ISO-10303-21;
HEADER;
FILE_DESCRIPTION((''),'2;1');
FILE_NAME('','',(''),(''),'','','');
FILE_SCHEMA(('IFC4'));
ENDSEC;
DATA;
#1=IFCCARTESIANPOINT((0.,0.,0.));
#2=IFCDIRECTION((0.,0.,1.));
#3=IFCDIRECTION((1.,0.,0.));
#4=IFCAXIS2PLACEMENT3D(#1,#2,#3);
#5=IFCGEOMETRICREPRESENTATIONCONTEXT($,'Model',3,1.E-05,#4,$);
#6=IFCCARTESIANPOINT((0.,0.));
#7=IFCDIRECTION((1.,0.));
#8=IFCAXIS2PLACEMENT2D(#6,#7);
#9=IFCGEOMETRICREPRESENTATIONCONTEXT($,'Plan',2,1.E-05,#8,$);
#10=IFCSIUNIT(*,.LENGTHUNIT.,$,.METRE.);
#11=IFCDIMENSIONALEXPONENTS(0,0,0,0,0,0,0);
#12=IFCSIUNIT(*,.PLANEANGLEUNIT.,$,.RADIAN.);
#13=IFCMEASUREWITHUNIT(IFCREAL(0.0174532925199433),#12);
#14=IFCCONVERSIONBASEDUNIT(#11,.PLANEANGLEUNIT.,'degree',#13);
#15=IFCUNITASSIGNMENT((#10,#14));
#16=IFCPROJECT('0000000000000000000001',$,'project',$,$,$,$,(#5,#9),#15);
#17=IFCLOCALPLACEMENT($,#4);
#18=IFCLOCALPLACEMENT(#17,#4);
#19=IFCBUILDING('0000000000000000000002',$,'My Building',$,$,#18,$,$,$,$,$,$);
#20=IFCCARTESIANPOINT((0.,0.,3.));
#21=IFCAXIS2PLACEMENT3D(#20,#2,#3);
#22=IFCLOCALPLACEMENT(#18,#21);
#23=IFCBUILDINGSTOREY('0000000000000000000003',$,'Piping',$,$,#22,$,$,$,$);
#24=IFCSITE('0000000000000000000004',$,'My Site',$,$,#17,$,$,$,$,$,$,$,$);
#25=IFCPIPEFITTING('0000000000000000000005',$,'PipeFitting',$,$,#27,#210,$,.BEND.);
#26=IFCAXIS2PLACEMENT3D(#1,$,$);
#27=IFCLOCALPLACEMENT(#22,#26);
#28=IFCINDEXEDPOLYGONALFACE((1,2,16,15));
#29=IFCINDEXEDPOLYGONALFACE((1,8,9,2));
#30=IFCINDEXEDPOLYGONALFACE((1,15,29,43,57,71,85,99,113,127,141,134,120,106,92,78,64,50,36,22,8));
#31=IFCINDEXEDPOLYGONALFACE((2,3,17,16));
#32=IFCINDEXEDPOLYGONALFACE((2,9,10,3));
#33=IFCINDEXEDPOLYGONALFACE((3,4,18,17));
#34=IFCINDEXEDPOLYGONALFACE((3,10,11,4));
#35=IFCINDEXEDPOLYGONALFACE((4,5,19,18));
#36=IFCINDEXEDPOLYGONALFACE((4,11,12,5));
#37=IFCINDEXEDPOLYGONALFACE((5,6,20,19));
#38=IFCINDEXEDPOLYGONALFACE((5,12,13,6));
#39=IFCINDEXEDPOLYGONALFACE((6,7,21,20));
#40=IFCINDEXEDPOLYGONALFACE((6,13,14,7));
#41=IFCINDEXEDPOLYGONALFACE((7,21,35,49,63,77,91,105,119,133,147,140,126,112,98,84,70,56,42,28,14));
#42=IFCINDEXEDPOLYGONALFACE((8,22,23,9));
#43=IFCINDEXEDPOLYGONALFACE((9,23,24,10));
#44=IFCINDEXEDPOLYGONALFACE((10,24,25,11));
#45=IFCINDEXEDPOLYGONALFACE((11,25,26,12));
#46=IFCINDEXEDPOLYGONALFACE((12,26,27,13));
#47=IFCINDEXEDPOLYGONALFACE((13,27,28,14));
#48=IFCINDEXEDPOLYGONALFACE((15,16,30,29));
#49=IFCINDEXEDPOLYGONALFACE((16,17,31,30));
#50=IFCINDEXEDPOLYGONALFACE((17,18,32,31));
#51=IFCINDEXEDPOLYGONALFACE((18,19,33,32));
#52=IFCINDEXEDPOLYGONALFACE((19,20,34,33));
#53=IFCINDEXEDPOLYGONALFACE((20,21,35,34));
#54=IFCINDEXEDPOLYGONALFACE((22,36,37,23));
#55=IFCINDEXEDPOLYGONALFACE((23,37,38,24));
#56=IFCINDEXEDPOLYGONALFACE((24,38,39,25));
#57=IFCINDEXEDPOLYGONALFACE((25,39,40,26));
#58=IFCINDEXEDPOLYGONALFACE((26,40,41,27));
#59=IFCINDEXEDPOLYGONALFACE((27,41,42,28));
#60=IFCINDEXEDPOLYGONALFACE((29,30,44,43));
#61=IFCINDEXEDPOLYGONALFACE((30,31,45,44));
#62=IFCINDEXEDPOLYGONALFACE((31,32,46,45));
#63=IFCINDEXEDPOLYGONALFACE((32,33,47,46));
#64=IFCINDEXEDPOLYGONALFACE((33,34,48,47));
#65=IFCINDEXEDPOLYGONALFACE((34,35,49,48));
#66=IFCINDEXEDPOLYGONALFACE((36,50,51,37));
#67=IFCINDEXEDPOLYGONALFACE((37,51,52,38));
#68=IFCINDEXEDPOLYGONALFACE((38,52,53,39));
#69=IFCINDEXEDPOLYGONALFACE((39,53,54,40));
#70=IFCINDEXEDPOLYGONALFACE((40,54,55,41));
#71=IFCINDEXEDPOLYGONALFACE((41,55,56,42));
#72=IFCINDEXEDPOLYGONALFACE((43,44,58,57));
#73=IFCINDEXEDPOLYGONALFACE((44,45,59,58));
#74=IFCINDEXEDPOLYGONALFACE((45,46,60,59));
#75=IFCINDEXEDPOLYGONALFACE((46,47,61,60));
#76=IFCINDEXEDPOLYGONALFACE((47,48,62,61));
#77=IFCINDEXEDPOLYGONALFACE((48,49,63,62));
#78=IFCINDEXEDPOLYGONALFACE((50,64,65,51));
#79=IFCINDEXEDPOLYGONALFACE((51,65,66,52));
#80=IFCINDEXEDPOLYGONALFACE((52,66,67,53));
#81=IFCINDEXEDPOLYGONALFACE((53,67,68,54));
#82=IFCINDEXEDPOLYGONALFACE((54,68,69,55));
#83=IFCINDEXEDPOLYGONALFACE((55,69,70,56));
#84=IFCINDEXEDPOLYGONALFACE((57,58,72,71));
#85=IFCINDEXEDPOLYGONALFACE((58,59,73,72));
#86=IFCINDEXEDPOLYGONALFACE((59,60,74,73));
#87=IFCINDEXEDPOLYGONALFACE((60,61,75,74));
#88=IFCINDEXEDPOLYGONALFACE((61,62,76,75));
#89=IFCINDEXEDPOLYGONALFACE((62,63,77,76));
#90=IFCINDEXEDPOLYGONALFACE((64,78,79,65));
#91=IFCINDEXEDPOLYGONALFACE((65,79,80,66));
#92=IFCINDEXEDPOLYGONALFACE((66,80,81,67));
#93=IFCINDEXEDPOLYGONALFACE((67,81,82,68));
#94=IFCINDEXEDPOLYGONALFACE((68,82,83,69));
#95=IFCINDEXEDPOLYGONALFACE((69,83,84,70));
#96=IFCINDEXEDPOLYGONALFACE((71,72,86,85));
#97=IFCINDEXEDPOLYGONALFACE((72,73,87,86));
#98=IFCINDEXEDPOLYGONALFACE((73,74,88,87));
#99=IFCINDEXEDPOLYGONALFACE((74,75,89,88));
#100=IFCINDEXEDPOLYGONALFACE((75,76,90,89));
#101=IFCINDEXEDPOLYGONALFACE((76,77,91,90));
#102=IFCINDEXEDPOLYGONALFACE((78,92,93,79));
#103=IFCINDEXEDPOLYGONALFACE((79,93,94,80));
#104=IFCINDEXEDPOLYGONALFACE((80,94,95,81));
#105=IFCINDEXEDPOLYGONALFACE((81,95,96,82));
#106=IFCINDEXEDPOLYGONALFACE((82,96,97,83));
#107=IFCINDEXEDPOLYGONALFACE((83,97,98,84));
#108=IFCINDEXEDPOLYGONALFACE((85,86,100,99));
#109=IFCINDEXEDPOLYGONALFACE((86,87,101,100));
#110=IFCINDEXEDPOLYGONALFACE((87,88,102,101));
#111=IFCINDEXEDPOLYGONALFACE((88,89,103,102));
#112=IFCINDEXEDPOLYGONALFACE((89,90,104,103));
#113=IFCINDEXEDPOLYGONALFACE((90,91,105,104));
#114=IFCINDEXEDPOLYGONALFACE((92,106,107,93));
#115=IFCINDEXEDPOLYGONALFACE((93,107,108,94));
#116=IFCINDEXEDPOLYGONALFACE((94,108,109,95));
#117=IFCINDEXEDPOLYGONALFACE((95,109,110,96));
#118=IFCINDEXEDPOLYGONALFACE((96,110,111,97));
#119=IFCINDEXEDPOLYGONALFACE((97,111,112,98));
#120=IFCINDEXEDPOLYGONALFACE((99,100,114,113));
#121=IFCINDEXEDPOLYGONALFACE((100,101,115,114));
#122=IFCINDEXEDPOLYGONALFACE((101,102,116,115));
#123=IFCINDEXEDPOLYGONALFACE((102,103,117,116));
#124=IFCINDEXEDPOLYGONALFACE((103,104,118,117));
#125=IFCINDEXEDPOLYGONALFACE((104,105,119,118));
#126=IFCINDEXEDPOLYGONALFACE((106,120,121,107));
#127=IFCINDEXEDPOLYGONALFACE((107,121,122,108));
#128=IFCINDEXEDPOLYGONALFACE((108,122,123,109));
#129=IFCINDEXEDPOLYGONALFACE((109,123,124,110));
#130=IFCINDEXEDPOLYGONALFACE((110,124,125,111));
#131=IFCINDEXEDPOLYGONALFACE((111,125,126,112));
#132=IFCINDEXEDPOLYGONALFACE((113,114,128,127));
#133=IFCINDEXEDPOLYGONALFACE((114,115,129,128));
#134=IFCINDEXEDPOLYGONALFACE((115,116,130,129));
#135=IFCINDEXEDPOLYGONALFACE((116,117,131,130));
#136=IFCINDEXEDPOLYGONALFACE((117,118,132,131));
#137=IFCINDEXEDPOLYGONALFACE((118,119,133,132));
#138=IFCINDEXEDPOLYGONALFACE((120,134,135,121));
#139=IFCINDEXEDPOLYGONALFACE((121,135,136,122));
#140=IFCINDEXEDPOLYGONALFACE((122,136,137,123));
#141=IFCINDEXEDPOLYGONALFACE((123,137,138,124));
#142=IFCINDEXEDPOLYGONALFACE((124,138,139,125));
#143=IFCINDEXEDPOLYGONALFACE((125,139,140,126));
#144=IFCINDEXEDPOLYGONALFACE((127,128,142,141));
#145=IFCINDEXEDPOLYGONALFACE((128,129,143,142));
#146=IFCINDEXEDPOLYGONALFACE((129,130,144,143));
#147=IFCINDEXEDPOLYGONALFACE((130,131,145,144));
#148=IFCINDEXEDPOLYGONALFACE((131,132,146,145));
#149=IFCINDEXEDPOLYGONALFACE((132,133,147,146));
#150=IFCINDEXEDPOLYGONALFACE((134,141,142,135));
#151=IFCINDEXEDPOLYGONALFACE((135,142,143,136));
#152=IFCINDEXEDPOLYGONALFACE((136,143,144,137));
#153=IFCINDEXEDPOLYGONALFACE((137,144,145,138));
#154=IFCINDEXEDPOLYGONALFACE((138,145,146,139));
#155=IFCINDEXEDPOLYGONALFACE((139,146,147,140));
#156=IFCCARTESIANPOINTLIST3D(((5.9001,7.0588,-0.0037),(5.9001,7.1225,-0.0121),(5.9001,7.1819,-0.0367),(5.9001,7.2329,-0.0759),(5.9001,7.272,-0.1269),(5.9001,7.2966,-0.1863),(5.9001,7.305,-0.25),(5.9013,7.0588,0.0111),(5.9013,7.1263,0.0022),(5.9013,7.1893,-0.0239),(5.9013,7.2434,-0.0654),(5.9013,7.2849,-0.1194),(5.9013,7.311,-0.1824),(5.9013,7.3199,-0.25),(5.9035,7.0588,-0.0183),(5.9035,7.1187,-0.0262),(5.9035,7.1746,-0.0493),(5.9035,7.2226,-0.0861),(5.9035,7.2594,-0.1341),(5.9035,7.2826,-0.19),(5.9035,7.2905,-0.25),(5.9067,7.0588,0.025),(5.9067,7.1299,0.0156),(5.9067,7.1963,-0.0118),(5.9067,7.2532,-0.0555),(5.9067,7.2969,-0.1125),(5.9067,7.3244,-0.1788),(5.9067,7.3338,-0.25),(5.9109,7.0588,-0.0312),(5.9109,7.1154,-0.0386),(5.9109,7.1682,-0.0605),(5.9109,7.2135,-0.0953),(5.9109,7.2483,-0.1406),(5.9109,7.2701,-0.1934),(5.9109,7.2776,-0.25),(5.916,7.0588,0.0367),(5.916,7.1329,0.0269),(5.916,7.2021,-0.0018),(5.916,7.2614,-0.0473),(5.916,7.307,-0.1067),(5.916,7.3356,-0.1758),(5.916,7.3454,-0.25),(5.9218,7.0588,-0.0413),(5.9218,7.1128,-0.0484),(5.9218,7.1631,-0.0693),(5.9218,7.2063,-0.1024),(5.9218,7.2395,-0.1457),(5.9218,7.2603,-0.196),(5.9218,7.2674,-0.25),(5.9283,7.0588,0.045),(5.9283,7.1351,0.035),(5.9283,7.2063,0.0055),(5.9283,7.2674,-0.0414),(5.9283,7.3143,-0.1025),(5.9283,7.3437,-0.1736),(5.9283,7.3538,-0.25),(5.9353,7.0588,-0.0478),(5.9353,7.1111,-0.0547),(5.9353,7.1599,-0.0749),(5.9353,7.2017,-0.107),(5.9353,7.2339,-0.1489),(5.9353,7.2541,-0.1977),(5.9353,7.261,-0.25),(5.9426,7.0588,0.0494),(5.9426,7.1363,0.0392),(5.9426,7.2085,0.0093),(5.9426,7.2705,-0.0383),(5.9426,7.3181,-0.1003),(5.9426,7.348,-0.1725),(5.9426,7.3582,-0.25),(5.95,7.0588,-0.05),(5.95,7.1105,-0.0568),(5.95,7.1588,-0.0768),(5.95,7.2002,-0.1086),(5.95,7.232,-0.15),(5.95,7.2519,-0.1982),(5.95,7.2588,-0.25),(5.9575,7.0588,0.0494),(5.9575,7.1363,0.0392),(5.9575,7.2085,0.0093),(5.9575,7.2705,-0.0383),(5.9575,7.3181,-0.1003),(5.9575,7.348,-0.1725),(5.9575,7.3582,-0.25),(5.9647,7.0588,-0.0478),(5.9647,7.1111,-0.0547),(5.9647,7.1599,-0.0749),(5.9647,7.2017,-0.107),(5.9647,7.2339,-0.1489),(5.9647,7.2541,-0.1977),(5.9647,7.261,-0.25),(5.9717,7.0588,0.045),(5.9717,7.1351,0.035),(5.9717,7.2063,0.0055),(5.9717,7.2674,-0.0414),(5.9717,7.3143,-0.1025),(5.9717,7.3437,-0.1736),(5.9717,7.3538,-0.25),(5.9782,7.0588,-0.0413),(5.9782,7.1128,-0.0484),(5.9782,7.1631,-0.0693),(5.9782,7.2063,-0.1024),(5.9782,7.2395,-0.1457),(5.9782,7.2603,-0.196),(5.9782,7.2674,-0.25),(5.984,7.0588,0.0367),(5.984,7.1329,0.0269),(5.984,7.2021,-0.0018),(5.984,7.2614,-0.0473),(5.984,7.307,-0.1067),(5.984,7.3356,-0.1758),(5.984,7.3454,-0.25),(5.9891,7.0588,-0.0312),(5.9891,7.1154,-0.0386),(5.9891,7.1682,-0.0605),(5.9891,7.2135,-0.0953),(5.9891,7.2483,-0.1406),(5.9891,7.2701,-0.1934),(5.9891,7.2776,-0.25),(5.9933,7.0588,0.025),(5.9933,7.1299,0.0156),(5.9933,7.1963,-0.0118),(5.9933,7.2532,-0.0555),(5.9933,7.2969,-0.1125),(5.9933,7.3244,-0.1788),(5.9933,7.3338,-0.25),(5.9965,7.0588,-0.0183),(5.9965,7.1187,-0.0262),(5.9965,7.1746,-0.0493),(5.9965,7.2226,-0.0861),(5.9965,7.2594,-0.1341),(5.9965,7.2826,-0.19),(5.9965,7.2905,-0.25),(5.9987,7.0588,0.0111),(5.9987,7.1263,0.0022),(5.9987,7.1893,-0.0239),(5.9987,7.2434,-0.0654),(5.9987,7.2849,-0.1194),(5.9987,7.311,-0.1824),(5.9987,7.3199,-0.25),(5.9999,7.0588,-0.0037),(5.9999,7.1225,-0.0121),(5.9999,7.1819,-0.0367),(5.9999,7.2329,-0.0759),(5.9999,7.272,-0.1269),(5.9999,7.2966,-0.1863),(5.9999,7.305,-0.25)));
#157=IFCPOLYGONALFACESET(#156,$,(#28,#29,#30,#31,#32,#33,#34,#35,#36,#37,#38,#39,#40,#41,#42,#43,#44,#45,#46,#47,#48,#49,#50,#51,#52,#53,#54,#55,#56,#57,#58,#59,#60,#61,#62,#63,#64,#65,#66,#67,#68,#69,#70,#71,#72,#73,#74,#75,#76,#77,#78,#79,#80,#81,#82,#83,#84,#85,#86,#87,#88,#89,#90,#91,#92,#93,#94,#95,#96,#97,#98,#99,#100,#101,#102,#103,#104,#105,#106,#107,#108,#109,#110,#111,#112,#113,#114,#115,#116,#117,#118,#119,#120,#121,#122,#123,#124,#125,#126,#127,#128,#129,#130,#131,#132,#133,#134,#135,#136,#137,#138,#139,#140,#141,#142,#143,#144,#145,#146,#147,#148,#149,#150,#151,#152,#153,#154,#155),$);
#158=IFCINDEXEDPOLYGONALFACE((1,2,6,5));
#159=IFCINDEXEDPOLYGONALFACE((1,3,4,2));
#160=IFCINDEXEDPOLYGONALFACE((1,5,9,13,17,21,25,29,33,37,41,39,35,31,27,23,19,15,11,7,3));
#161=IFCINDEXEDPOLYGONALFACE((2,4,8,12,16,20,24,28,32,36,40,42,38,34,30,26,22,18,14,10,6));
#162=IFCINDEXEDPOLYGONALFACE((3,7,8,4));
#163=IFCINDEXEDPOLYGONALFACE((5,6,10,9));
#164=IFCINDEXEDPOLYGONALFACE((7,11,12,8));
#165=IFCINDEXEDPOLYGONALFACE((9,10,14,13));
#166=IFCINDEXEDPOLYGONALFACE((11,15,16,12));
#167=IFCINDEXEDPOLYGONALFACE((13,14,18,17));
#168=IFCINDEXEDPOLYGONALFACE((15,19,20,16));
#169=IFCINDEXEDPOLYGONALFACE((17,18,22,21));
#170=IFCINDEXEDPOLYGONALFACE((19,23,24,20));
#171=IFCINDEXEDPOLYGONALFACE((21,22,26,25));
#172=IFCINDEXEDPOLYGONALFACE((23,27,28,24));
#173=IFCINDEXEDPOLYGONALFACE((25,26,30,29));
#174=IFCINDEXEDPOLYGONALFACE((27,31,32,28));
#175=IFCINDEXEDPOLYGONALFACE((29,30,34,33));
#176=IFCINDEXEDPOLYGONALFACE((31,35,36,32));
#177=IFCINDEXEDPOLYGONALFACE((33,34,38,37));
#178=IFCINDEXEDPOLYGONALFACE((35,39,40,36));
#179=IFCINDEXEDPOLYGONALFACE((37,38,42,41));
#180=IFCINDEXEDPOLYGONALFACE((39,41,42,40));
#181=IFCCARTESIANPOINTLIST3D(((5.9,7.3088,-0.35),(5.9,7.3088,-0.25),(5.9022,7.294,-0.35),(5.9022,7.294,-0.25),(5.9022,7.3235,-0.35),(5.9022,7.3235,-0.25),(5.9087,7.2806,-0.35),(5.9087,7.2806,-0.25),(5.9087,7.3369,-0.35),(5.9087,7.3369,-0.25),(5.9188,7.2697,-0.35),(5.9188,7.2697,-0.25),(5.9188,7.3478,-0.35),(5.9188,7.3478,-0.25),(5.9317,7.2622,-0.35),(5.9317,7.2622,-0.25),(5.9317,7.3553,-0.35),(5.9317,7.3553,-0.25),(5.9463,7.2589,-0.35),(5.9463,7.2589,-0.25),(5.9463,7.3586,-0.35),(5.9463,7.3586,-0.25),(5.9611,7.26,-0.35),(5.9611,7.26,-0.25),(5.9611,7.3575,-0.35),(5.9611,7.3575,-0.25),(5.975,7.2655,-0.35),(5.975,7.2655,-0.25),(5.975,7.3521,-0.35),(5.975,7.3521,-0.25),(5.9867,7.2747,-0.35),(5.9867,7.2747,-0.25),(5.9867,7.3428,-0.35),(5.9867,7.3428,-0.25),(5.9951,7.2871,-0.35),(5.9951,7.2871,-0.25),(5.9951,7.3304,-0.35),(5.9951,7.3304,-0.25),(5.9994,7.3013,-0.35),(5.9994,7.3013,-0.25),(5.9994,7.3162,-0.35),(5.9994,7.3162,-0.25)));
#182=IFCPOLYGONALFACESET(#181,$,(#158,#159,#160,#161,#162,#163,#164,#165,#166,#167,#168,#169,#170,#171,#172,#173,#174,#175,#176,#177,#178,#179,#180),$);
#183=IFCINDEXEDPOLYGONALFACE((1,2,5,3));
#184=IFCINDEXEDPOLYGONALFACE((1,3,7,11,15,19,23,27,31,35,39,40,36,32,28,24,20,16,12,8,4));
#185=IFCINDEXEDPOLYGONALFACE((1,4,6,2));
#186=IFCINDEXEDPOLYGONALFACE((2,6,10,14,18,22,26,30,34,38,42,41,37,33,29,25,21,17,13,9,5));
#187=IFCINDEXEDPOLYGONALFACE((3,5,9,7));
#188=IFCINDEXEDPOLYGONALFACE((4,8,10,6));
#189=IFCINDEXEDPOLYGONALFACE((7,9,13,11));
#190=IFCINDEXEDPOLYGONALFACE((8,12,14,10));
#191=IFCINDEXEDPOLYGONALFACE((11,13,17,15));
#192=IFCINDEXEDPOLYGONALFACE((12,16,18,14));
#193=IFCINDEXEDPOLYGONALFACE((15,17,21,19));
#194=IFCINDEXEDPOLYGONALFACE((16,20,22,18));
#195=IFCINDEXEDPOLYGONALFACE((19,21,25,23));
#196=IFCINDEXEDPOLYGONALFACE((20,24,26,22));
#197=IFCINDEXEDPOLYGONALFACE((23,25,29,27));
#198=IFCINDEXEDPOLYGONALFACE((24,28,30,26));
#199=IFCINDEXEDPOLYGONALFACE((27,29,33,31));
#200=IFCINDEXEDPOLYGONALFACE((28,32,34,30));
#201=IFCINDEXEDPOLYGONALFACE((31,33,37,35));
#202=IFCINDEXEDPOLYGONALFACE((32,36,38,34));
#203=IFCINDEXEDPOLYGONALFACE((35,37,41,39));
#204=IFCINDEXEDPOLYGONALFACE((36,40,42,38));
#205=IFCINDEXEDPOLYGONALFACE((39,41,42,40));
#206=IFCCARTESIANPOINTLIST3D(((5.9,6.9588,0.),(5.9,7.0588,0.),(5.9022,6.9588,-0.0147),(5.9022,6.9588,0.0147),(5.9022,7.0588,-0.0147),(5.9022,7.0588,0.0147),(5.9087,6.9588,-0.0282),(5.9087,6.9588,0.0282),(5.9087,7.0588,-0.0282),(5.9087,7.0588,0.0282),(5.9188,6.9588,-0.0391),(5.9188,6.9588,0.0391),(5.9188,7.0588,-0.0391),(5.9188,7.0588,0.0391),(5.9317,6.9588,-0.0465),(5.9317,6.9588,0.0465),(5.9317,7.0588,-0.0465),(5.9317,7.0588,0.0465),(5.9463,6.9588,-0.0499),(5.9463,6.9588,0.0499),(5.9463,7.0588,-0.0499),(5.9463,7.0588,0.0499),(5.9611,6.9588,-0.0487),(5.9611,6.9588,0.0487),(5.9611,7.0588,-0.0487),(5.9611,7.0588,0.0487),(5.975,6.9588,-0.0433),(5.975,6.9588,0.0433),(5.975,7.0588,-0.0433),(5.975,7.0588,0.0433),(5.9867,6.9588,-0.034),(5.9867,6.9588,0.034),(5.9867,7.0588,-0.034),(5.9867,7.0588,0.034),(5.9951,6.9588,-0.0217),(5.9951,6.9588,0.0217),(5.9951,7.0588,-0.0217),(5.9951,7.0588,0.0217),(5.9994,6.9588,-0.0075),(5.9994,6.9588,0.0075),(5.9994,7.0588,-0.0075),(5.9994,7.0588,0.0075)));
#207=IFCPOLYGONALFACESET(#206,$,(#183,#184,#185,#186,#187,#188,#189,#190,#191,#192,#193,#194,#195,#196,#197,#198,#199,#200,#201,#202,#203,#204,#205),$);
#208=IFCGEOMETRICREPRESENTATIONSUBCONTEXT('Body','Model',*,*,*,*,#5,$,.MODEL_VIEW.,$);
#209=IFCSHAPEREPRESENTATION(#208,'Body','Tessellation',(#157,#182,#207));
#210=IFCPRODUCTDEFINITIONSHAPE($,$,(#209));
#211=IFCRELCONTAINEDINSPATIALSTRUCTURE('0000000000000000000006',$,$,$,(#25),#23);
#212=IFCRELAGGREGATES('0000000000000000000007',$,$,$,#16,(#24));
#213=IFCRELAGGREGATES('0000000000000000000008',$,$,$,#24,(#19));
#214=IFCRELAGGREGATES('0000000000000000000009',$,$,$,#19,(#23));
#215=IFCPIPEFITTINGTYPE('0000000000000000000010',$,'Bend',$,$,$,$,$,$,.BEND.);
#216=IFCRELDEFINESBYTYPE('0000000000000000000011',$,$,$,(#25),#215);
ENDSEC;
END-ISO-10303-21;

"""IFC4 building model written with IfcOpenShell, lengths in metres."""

from ifc_helpers import new_model, entity, si_unit, converted_unit, frame, origin_with_axes, origin_2d_with_axis, place, context, subcontext, project, spatial, circle, extrude, source, transform, mapped, type_object, type_shapes, element, save


model = new_model("IFC4")

# Units and contexts
model_context = context("Model", 3, precision=1e-05, world=origin_with_axes())
plan_context = context("Plan", 2, precision=1e-05, world=origin_2d_with_axis())
body_context = subcontext(model_context, "Body", "Model", "MODEL_VIEW")
ifc_project = project(units=[si_unit("LENGTHUNIT", "METRE"), converted_unit("PLANEANGLEUNIT", "degree", entity("IfcReal", 0.0174532925199433), si_unit("PLANEANGLEUNIT", "RADIAN"), dimensions=[0, 0, 0, 0, 0, 0, 0])], contexts=[model_context, plan_context])

# Site, building, storey
site_placement = place(None, origin_with_axes())
site = spatial("IfcSite", under=ifc_project, at=site_placement, Name="My Site")
building_placement = place(site_placement, origin_with_axes())
building = spatial("IfcBuilding", under=site, at=building_placement, Name="My Building")
storey_placement = place(building_placement, frame((0.0, 0.0, 3.0), z_axis=(0.0, 0.0, 1.0), x_axis=(1.0, 0.0, 0.0)))
storey = spatial("IfcBuildingStorey", under=building, at=storey_placement, Name="Piping")

# Pipe fitting
pipe_fitting_type = type_object("IfcPipeFittingType", Name="Bend", PredefinedType="BEND")
shared_shape = source(origin_with_axes(), body_context, "Body", "SolidModel", [
    entity("IfcSweptDiskSolid", entity("IfcIndexedPolyCurve", entity("IfcCartesianPointList3D", [[0.0, 0.0, -0.1], [0.0, -0.0732, -0.2768], [0.0, -0.25, -0.35]]), [entity("IfcArcIndex", [1, 2, 3])]), 0.05),
    extrude(circle(Radius=0.05), origin_with_axes(), (0.0, 0.0, -1.0), 0.1),
    extrude(circle(Radius=0.05), frame((0.0, -0.25, -0.35), z_axis=(0.0, -1.0, 0.0), x_axis=(1.0, 0.0, 0.0)), (0.0, 0.0, 1.0), 0.1),
])
type_shapes(pipe_fitting_type, [shared_shape])
for number, where, z_axis, x_axis, name in (
    (1, (5.95, 7.3088, -0.35), (0.0, 0.0, -1.0), (-1.0, 0.0, 0.0), "PipeFitting"),
):
    element("IfcPipeFitting", number, at=place(storey_placement, frame(where, z_axis=z_axis, x_axis=x_axis)), inside=storey, type_object=pipe_fitting_type, Name=name, PredefinedType="BEND", context=body_context, shape_type="MappedRepresentation", body=[
        mapped(shared_shape, transform((0.0, 0.0, 0.0), x_axis=(1.0, 0.0, 0.0), y_axis=(0.0, 1.0, 0.0), z_axis=(0.0, 0.0, 1.0), scale=1.0)),
    ])

save(model, "model.ifc")
